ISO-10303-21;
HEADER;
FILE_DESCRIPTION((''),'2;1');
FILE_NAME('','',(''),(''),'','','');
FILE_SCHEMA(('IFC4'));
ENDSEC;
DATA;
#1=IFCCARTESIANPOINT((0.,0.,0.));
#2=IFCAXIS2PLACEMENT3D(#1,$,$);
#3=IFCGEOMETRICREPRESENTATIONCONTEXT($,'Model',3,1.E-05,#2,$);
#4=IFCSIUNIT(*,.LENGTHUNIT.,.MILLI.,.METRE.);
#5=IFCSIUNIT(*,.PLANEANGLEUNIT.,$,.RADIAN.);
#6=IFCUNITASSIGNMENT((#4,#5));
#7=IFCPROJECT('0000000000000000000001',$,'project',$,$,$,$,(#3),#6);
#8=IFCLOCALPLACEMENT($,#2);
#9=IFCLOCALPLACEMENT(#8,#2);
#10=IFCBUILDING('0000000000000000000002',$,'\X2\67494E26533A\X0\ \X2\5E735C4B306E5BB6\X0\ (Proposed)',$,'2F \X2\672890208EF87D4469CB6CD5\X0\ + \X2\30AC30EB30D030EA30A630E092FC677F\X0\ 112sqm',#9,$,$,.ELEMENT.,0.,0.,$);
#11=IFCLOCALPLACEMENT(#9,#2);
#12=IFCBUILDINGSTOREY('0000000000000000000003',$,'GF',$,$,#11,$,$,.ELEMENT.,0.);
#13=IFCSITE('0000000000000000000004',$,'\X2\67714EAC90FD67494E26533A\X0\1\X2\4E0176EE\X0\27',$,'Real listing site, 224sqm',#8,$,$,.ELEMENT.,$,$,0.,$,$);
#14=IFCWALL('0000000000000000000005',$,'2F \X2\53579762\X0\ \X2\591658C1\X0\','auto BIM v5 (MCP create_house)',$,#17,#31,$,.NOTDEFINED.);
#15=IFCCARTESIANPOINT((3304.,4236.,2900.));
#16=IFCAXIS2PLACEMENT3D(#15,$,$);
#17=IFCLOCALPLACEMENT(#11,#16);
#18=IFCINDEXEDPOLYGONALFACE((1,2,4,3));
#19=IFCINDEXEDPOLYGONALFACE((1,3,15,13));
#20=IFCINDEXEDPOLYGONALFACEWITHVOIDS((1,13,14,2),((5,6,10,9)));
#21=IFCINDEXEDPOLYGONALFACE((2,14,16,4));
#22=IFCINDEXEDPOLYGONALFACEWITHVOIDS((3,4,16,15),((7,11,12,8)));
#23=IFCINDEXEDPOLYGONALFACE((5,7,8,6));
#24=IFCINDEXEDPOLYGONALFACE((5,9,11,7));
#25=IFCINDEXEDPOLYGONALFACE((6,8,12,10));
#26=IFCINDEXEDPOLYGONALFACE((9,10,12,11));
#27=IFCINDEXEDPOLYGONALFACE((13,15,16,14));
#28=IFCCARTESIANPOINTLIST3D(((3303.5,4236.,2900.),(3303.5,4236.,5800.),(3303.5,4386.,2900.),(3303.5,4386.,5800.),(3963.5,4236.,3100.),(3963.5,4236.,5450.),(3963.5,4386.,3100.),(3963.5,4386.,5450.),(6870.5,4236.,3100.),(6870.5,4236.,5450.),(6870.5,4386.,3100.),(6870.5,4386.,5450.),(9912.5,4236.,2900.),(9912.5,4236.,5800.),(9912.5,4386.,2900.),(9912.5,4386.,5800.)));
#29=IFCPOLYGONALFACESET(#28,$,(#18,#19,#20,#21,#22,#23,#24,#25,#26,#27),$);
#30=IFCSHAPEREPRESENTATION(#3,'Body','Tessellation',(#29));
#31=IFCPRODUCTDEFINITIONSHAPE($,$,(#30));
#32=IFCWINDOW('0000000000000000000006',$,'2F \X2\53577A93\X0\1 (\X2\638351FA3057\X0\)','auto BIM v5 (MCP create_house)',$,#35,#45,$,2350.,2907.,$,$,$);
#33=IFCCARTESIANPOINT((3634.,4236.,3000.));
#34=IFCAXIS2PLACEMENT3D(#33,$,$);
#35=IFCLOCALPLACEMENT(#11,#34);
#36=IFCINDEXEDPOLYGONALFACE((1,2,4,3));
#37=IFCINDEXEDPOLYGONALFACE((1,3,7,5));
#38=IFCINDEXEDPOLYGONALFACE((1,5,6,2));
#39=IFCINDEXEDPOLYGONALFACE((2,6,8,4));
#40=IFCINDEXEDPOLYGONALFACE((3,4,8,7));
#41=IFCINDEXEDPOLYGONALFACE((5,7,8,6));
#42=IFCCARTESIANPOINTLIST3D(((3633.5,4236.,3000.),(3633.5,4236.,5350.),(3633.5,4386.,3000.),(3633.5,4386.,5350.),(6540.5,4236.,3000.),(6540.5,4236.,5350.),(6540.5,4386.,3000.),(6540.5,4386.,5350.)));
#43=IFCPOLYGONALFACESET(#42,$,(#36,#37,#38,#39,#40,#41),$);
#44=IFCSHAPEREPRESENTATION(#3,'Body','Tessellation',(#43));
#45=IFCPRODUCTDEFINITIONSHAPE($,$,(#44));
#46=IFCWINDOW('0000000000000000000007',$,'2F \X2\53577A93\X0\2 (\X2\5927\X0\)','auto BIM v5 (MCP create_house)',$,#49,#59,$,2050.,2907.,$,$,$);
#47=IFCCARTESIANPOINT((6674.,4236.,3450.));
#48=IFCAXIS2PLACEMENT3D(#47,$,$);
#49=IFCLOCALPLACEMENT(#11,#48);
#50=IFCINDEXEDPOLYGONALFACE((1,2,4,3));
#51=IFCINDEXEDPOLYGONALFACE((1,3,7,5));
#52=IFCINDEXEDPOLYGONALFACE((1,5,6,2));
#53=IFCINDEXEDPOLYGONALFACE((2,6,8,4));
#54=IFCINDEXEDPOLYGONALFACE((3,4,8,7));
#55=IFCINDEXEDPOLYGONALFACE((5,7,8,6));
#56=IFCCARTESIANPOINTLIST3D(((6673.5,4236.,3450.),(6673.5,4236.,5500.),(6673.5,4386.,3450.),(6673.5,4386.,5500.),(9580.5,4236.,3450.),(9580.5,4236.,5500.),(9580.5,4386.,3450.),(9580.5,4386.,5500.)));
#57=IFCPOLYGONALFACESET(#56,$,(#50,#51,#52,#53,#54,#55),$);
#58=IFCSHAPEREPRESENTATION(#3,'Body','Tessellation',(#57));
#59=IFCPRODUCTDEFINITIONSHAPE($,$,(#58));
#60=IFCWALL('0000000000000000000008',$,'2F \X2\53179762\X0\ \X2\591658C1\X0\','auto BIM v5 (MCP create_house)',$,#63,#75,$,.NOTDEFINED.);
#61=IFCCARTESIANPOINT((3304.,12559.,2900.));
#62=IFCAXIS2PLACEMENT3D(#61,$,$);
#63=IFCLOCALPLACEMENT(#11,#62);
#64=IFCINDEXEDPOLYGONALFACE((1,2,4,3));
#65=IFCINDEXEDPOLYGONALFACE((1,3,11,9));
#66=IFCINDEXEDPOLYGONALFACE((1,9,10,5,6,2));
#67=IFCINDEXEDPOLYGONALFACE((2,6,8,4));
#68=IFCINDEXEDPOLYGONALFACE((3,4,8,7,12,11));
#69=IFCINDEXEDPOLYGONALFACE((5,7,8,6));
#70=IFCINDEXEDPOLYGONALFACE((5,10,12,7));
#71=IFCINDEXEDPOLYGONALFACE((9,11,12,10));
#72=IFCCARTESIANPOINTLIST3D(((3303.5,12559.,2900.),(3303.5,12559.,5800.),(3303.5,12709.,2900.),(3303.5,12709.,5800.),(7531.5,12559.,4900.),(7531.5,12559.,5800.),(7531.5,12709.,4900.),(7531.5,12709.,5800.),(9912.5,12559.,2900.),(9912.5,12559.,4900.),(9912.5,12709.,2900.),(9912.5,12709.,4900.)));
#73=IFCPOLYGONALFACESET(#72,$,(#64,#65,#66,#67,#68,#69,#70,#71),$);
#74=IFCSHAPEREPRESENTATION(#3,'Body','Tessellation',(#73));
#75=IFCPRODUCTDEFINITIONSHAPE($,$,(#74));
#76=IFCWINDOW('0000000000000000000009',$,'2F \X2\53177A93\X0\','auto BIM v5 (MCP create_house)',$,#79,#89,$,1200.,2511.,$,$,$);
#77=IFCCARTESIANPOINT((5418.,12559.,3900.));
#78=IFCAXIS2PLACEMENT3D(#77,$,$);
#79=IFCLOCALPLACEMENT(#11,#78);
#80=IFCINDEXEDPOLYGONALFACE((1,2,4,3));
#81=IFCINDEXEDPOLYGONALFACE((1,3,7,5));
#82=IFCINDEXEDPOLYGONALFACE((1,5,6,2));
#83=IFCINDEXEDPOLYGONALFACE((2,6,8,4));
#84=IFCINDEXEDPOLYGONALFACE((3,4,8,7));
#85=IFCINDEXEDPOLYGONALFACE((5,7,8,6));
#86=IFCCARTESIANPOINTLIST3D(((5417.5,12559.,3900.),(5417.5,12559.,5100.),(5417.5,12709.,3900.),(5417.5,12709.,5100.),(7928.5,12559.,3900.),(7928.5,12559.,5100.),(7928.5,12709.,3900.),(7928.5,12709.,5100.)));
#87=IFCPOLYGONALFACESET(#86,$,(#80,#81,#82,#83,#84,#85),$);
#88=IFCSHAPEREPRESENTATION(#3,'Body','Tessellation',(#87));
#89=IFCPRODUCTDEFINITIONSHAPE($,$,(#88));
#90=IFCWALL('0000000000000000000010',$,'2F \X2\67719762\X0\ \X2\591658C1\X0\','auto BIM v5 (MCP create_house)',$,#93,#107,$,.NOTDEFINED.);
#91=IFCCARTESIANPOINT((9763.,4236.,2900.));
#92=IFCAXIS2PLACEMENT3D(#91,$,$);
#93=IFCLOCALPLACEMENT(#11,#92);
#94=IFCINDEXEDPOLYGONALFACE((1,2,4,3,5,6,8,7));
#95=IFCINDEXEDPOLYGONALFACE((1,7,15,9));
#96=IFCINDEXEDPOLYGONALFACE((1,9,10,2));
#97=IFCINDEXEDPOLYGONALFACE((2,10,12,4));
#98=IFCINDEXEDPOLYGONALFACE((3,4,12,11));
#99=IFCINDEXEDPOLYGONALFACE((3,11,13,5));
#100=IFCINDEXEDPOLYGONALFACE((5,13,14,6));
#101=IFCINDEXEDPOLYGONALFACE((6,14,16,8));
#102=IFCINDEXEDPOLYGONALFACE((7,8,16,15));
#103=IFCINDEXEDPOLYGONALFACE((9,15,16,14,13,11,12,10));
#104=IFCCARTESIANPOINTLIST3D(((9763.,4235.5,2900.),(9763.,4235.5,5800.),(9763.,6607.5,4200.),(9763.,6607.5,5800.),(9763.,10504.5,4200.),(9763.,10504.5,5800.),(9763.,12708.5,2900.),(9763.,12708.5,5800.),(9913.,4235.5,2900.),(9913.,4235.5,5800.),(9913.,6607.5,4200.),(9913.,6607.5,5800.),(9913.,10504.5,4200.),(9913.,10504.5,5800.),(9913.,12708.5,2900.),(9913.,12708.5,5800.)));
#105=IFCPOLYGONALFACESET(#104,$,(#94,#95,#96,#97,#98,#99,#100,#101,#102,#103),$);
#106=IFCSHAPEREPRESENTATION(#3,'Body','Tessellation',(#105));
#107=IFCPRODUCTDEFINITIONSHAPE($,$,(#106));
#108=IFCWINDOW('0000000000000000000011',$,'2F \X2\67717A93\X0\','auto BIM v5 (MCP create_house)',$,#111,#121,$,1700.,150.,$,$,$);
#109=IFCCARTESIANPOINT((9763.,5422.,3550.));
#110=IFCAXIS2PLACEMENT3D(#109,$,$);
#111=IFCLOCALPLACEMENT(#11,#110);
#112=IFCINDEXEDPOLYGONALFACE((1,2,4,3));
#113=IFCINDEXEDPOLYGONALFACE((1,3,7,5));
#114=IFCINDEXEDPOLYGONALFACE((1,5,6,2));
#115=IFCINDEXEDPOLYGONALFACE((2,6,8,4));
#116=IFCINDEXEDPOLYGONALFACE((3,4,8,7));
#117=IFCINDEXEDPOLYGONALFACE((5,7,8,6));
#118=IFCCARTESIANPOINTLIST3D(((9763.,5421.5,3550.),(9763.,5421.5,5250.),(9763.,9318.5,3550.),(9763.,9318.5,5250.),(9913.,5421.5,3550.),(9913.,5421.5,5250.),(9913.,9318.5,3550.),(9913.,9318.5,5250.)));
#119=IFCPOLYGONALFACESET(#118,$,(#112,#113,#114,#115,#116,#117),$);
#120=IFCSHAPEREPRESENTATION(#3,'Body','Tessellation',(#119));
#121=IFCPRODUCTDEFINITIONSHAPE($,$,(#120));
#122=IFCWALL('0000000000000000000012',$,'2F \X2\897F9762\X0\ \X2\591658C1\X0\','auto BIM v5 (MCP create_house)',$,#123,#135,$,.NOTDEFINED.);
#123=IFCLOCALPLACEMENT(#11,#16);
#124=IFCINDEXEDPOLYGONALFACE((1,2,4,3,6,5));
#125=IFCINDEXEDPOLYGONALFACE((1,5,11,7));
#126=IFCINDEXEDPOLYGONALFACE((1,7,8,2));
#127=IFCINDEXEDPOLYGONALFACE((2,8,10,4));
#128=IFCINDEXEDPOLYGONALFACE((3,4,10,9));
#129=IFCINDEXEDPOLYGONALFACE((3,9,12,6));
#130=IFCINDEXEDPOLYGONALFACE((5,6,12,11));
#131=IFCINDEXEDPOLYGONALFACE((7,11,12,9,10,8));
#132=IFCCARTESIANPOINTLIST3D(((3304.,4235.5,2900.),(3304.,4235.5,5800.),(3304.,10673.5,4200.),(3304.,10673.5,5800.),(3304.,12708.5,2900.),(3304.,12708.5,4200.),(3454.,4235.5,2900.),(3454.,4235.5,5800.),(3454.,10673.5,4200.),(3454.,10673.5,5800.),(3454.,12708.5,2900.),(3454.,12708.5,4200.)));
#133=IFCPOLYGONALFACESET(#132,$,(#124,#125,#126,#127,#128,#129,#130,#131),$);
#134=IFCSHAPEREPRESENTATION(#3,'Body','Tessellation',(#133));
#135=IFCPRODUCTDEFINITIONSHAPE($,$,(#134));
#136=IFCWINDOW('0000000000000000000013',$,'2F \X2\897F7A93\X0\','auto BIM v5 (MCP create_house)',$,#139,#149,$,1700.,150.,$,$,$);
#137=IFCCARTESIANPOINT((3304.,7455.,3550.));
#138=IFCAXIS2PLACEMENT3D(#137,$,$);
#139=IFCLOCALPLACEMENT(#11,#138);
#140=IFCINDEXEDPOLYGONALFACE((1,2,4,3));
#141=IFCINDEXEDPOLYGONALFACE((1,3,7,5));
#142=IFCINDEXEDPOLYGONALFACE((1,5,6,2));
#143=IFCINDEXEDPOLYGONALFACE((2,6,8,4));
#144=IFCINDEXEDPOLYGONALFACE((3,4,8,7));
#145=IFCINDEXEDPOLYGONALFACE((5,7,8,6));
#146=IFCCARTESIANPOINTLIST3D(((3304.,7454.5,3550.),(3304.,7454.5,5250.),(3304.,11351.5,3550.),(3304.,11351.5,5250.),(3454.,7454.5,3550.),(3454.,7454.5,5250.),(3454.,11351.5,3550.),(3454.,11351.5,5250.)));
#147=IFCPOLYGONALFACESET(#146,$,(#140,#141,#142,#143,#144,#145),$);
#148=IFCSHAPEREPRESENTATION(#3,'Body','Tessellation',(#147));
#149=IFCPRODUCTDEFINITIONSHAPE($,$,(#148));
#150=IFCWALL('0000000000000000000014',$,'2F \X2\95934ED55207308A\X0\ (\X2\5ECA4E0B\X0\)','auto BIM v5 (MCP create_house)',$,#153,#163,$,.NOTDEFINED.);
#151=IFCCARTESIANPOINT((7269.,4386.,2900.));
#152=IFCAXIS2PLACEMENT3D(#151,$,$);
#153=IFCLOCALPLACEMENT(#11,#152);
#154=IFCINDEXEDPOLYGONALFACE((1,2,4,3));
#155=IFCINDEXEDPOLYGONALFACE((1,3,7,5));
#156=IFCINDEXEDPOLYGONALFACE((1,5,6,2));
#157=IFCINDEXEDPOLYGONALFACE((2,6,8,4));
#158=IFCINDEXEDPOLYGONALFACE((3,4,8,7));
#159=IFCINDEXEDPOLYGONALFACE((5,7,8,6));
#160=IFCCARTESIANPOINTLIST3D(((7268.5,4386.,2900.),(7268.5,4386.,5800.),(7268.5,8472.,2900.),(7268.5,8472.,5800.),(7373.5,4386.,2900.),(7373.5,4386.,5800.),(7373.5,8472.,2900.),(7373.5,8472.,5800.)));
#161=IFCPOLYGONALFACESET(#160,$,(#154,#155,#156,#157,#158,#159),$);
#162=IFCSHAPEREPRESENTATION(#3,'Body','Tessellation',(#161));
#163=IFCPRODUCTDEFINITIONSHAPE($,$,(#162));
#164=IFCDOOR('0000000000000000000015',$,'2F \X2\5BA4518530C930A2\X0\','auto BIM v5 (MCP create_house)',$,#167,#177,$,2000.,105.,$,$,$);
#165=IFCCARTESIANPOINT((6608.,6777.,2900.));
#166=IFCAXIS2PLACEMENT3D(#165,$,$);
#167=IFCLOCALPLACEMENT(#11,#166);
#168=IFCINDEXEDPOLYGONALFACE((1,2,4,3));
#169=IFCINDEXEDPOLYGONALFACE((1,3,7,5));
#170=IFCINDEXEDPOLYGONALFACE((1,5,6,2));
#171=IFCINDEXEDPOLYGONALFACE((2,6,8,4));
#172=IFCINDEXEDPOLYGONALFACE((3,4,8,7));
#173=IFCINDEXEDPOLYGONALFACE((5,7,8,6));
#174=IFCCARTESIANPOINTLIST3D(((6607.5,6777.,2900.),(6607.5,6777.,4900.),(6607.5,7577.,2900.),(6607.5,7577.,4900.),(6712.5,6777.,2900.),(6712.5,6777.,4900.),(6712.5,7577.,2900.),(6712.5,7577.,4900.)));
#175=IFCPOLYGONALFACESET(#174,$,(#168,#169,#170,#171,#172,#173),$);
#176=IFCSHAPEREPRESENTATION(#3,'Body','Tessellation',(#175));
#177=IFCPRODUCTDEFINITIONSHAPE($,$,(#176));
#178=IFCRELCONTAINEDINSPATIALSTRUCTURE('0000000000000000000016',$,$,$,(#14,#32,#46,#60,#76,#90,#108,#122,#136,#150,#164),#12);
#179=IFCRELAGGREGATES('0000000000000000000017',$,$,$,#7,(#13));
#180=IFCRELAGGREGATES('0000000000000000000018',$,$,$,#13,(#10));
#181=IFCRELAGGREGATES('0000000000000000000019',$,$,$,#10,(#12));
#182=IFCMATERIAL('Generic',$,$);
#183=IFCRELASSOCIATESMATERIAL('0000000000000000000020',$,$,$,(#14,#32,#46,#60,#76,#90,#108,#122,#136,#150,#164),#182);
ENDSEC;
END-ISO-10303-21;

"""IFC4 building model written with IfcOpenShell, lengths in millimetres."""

from ifc_helpers import new_model, si_unit, frame, frame_2d, origin, place, context, project, spatial, rectangle, extrude, material, element, fill, save


model = new_model("IFC4")

# Units and contexts
model_context = context("Model", 3, precision=1e-05, world=origin())
ifc_project = project(units=[si_unit("LENGTHUNIT", "METRE", prefix="MILLI"), si_unit("PLANEANGLEUNIT", "RADIAN")], contexts=[model_context])

# Site, building, storey
site_placement = place(None, origin())
site = spatial("IfcSite", under=ifc_project, at=site_placement, Name="東京都杉並区1丁目27", ObjectType="Real listing site, 224sqm", CompositionType="ELEMENT", RefElevation=0.0)
building_placement = place(site_placement, origin())
building = spatial("IfcBuilding", under=site, at=building_placement, Name="杉並区 平屋の家 (Proposed)", ObjectType="2F 木造軸組構法 + ガルバリウム鋼板 112sqm", CompositionType="ELEMENT", ElevationOfRefHeight=0.0, ElevationOfTerrain=0.0)
storey_placement = place(building_placement, origin())
storey = spatial("IfcBuildingStorey", under=building, at=storey_placement, Name="GF", CompositionType="ELEMENT", Elevation=0.0)

# Shared definitions
ifc_material = material(Name="Generic")

# Wall, openings, windows
wall_1_placement = place(storey_placement, frame((3304.0, 4236.0, 2900.0)))
wall_1 = element("IfcWall", 1, at=wall_1_placement, inside=storey, material=ifc_material, Name="2F 南面 外壁", Description="auto BIM v5 (MCP create_house)", PredefinedType="NOTDEFINED", context=model_context, shape_type="SweptSolid", body=[
    extrude(rectangle(XDim=6609.0, YDim=150.0, at=frame_2d((3304.0, 75.0))), frame((3304.0, 4236.0, 2900.0)), (0.0, 0.0, 1.0), 2900.0),
])
opening_1_placement = place(storey_placement, frame((3634.0, 4236.0, 3000.0)))
opening_1 = element("IfcOpeningElement", 2, at=opening_1_placement, cuts=wall_1, PredefinedType="NOTDEFINED", context=model_context, shape_type="SweptSolid", body=[
    extrude(rectangle(XDim=2907.0, YDim=150.0, at=frame_2d((1453.0, 75.0))), frame((3634.0, 4236.0, 3000.0)), (0.0, 0.0, 1.0), 2350.0),
])
opening_2_placement = place(storey_placement, frame((6674.0, 4236.0, 3450.0)))
opening_2 = element("IfcOpeningElement", 3, at=opening_2_placement, cuts=wall_1, PredefinedType="NOTDEFINED", context=model_context, shape_type="SweptSolid", body=[
    extrude(rectangle(XDim=2907.0, YDim=150.0, at=frame_2d((1453.0, 75.0))), frame((6674.0, 4236.0, 3450.0)), (0.0, 0.0, 1.0), 2050.0),
])
window_1_placement = place(storey_placement, frame((3634.0, 4236.0, 3000.0)))
window_1 = element("IfcWindow", 4, at=window_1_placement, inside=storey, material=ifc_material, Name="2F 南窓1 (掃出し)", Description="auto BIM v5 (MCP create_house)", OverallHeight=2350.0, OverallWidth=2907.0, context=model_context, shape_type="SweptSolid", body=[
    extrude(rectangle(XDim=2907.0, YDim=150.0, at=frame_2d((1453.0, 75.0))), frame((3634.0, 4236.0, 3000.0)), (0.0, 0.0, 1.0), 2350.0),
])
fill(opening_1, window_1)
window_2_placement = place(storey_placement, frame((6674.0, 4236.0, 3450.0)))
window_2 = element("IfcWindow", 5, at=window_2_placement, inside=storey, material=ifc_material, Name="2F 南窓2 (大)", Description="auto BIM v5 (MCP create_house)", OverallHeight=2050.0, OverallWidth=2907.0, context=model_context, shape_type="SweptSolid", body=[
    extrude(rectangle(XDim=2907.0, YDim=150.0, at=frame_2d((1453.0, 75.0))), frame((6674.0, 4236.0, 3450.0)), (0.0, 0.0, 1.0), 2050.0),
])
fill(opening_2, window_2)

# Walls, openings, windows
wall_2_placement = place(storey_placement, frame((3304.0, 12559.0, 2900.0)))
wall_2 = element("IfcWall", 6, at=wall_2_placement, inside=storey, material=ifc_material, Name="2F 北面 外壁", Description="auto BIM v5 (MCP create_house)", PredefinedType="NOTDEFINED", context=model_context, shape_type="SweptSolid", body=[
    extrude(rectangle(XDim=6609.0, YDim=150.0, at=frame_2d((3304.0, 75.0))), frame((3304.0, 12559.0, 2900.0)), (0.0, 0.0, 1.0), 2900.0),
])
opening_3_placement = place(storey_placement, frame((5418.0, 12559.0, 3900.0)))
opening_3 = element("IfcOpeningElement", 7, at=opening_3_placement, cuts=wall_2, PredefinedType="NOTDEFINED", context=model_context, shape_type="SweptSolid", body=[
    extrude(rectangle(XDim=2511.0, YDim=150.0, at=frame_2d((1255.0, 75.0))), frame((5418.0, 12559.0, 3900.0)), (0.0, 0.0, 1.0), 1200.0),
])
window_3_placement = place(storey_placement, frame((5418.0, 12559.0, 3900.0)))
window_3 = element("IfcWindow", 8, at=window_3_placement, inside=storey, material=ifc_material, Name="2F 北窓", Description="auto BIM v5 (MCP create_house)", OverallHeight=1200.0, OverallWidth=2511.0, context=model_context, shape_type="SweptSolid", body=[
    extrude(rectangle(XDim=2511.0, YDim=150.0, at=frame_2d((1255.0, 75.0))), frame((5418.0, 12559.0, 3900.0)), (0.0, 0.0, 1.0), 1200.0),
])
fill(opening_3, window_3)
wall_3_placement = place(storey_placement, frame((9763.0, 4236.0, 2900.0)))
wall_3 = element("IfcWall", 9, at=wall_3_placement, inside=storey, material=ifc_material, Name="2F 東面 外壁", Description="auto BIM v5 (MCP create_house)", PredefinedType="NOTDEFINED", context=model_context, shape_type="SweptSolid", body=[
    extrude(rectangle(XDim=150.0, YDim=8473.0, at=frame_2d((75.0, 4236.0))), frame((9763.0, 4236.0, 2900.0)), (0.0, 0.0, 1.0), 2900.0),
])
opening_4_placement = place(storey_placement, frame((9763.0, 5422.0, 3550.0)))
opening_4 = element("IfcOpeningElement", 10, at=opening_4_placement, cuts=wall_3, PredefinedType="NOTDEFINED", context=model_context, shape_type="SweptSolid", body=[
    extrude(rectangle(XDim=150.0, YDim=3897.0, at=frame_2d((75.0, 1948.0))), frame((9763.0, 5422.0, 3550.0)), (0.0, 0.0, 1.0), 1700.0),
])
window_4_placement = place(storey_placement, frame((9763.0, 5422.0, 3550.0)))
window_4 = element("IfcWindow", 11, at=window_4_placement, inside=storey, material=ifc_material, Name="2F 東窓", Description="auto BIM v5 (MCP create_house)", OverallHeight=1700.0, OverallWidth=150.0, context=model_context, shape_type="SweptSolid", body=[
    extrude(rectangle(XDim=150.0, YDim=3897.0, at=frame_2d((75.0, 1948.0))), frame((9763.0, 5422.0, 3550.0)), (0.0, 0.0, 1.0), 1700.0),
])
fill(opening_4, window_4)
wall_4_placement = place(storey_placement, frame((3304.0, 4236.0, 2900.0)))
wall_4 = element("IfcWall", 12, at=wall_4_placement, inside=storey, material=ifc_material, Name="2F 西面 外壁", Description="auto BIM v5 (MCP create_house)", PredefinedType="NOTDEFINED", context=model_context, shape_type="SweptSolid", body=[
    extrude(rectangle(XDim=150.0, YDim=8473.0, at=frame_2d((75.0, 4236.0))), frame((3304.0, 4236.0, 2900.0)), (0.0, 0.0, 1.0), 2900.0),
])
opening_5_placement = place(storey_placement, frame((3304.0, 7455.0, 3550.0)))
opening_5 = element("IfcOpeningElement", 13, at=opening_5_placement, cuts=wall_4, PredefinedType="NOTDEFINED", context=model_context, shape_type="SweptSolid", body=[
    extrude(rectangle(XDim=150.0, YDim=3897.0, at=frame_2d((75.0, 1948.0))), frame((3304.0, 7455.0, 3550.0)), (0.0, 0.0, 1.0), 1700.0),
])
window_5_placement = place(storey_placement, frame((3304.0, 7455.0, 3550.0)))
window_5 = element("IfcWindow", 14, at=window_5_placement, inside=storey, material=ifc_material, Name="2F 西窓", Description="auto BIM v5 (MCP create_house)", OverallHeight=1700.0, OverallWidth=150.0, context=model_context, shape_type="SweptSolid", body=[
    extrude(rectangle(XDim=150.0, YDim=3897.0, at=frame_2d((75.0, 1948.0))), frame((3304.0, 7455.0, 3550.0)), (0.0, 0.0, 1.0), 1700.0),
])
fill(opening_5, window_5)

# Wall
wall_5_placement = place(storey_placement, frame((7269.0, 4386.0, 2900.0)))
element("IfcWall", 15, at=wall_5_placement, inside=storey, material=ifc_material, Name="2F 間仕切り (廊下)", Description="auto BIM v5 (MCP create_house)", PredefinedType="NOTDEFINED", context=model_context, shape_type="SweptSolid", body=[
    extrude(rectangle(XDim=105.0, YDim=4086.0, at=frame_2d((52.0, 2043.0))), frame((7269.0, 4386.0, 2900.0)), (0.0, 0.0, 1.0), 2900.0),
])

# Door
door_1_placement = place(storey_placement, frame((6608.0, 6777.0, 2900.0)))
element("IfcDoor", 16, at=door_1_placement, inside=storey, material=ifc_material, Name="2F 室内ドア", Description="auto BIM v5 (MCP create_house)", OverallHeight=2000.0, OverallWidth=105.0, context=model_context, shape_type="SweptSolid", body=[
    extrude(rectangle(XDim=105.0, YDim=800.0, at=frame_2d((52.0, 400.0))), frame((6608.0, 6777.0, 2900.0)), (0.0, 0.0, 1.0), 2000.0),
])

save(model, "model.ifc")
